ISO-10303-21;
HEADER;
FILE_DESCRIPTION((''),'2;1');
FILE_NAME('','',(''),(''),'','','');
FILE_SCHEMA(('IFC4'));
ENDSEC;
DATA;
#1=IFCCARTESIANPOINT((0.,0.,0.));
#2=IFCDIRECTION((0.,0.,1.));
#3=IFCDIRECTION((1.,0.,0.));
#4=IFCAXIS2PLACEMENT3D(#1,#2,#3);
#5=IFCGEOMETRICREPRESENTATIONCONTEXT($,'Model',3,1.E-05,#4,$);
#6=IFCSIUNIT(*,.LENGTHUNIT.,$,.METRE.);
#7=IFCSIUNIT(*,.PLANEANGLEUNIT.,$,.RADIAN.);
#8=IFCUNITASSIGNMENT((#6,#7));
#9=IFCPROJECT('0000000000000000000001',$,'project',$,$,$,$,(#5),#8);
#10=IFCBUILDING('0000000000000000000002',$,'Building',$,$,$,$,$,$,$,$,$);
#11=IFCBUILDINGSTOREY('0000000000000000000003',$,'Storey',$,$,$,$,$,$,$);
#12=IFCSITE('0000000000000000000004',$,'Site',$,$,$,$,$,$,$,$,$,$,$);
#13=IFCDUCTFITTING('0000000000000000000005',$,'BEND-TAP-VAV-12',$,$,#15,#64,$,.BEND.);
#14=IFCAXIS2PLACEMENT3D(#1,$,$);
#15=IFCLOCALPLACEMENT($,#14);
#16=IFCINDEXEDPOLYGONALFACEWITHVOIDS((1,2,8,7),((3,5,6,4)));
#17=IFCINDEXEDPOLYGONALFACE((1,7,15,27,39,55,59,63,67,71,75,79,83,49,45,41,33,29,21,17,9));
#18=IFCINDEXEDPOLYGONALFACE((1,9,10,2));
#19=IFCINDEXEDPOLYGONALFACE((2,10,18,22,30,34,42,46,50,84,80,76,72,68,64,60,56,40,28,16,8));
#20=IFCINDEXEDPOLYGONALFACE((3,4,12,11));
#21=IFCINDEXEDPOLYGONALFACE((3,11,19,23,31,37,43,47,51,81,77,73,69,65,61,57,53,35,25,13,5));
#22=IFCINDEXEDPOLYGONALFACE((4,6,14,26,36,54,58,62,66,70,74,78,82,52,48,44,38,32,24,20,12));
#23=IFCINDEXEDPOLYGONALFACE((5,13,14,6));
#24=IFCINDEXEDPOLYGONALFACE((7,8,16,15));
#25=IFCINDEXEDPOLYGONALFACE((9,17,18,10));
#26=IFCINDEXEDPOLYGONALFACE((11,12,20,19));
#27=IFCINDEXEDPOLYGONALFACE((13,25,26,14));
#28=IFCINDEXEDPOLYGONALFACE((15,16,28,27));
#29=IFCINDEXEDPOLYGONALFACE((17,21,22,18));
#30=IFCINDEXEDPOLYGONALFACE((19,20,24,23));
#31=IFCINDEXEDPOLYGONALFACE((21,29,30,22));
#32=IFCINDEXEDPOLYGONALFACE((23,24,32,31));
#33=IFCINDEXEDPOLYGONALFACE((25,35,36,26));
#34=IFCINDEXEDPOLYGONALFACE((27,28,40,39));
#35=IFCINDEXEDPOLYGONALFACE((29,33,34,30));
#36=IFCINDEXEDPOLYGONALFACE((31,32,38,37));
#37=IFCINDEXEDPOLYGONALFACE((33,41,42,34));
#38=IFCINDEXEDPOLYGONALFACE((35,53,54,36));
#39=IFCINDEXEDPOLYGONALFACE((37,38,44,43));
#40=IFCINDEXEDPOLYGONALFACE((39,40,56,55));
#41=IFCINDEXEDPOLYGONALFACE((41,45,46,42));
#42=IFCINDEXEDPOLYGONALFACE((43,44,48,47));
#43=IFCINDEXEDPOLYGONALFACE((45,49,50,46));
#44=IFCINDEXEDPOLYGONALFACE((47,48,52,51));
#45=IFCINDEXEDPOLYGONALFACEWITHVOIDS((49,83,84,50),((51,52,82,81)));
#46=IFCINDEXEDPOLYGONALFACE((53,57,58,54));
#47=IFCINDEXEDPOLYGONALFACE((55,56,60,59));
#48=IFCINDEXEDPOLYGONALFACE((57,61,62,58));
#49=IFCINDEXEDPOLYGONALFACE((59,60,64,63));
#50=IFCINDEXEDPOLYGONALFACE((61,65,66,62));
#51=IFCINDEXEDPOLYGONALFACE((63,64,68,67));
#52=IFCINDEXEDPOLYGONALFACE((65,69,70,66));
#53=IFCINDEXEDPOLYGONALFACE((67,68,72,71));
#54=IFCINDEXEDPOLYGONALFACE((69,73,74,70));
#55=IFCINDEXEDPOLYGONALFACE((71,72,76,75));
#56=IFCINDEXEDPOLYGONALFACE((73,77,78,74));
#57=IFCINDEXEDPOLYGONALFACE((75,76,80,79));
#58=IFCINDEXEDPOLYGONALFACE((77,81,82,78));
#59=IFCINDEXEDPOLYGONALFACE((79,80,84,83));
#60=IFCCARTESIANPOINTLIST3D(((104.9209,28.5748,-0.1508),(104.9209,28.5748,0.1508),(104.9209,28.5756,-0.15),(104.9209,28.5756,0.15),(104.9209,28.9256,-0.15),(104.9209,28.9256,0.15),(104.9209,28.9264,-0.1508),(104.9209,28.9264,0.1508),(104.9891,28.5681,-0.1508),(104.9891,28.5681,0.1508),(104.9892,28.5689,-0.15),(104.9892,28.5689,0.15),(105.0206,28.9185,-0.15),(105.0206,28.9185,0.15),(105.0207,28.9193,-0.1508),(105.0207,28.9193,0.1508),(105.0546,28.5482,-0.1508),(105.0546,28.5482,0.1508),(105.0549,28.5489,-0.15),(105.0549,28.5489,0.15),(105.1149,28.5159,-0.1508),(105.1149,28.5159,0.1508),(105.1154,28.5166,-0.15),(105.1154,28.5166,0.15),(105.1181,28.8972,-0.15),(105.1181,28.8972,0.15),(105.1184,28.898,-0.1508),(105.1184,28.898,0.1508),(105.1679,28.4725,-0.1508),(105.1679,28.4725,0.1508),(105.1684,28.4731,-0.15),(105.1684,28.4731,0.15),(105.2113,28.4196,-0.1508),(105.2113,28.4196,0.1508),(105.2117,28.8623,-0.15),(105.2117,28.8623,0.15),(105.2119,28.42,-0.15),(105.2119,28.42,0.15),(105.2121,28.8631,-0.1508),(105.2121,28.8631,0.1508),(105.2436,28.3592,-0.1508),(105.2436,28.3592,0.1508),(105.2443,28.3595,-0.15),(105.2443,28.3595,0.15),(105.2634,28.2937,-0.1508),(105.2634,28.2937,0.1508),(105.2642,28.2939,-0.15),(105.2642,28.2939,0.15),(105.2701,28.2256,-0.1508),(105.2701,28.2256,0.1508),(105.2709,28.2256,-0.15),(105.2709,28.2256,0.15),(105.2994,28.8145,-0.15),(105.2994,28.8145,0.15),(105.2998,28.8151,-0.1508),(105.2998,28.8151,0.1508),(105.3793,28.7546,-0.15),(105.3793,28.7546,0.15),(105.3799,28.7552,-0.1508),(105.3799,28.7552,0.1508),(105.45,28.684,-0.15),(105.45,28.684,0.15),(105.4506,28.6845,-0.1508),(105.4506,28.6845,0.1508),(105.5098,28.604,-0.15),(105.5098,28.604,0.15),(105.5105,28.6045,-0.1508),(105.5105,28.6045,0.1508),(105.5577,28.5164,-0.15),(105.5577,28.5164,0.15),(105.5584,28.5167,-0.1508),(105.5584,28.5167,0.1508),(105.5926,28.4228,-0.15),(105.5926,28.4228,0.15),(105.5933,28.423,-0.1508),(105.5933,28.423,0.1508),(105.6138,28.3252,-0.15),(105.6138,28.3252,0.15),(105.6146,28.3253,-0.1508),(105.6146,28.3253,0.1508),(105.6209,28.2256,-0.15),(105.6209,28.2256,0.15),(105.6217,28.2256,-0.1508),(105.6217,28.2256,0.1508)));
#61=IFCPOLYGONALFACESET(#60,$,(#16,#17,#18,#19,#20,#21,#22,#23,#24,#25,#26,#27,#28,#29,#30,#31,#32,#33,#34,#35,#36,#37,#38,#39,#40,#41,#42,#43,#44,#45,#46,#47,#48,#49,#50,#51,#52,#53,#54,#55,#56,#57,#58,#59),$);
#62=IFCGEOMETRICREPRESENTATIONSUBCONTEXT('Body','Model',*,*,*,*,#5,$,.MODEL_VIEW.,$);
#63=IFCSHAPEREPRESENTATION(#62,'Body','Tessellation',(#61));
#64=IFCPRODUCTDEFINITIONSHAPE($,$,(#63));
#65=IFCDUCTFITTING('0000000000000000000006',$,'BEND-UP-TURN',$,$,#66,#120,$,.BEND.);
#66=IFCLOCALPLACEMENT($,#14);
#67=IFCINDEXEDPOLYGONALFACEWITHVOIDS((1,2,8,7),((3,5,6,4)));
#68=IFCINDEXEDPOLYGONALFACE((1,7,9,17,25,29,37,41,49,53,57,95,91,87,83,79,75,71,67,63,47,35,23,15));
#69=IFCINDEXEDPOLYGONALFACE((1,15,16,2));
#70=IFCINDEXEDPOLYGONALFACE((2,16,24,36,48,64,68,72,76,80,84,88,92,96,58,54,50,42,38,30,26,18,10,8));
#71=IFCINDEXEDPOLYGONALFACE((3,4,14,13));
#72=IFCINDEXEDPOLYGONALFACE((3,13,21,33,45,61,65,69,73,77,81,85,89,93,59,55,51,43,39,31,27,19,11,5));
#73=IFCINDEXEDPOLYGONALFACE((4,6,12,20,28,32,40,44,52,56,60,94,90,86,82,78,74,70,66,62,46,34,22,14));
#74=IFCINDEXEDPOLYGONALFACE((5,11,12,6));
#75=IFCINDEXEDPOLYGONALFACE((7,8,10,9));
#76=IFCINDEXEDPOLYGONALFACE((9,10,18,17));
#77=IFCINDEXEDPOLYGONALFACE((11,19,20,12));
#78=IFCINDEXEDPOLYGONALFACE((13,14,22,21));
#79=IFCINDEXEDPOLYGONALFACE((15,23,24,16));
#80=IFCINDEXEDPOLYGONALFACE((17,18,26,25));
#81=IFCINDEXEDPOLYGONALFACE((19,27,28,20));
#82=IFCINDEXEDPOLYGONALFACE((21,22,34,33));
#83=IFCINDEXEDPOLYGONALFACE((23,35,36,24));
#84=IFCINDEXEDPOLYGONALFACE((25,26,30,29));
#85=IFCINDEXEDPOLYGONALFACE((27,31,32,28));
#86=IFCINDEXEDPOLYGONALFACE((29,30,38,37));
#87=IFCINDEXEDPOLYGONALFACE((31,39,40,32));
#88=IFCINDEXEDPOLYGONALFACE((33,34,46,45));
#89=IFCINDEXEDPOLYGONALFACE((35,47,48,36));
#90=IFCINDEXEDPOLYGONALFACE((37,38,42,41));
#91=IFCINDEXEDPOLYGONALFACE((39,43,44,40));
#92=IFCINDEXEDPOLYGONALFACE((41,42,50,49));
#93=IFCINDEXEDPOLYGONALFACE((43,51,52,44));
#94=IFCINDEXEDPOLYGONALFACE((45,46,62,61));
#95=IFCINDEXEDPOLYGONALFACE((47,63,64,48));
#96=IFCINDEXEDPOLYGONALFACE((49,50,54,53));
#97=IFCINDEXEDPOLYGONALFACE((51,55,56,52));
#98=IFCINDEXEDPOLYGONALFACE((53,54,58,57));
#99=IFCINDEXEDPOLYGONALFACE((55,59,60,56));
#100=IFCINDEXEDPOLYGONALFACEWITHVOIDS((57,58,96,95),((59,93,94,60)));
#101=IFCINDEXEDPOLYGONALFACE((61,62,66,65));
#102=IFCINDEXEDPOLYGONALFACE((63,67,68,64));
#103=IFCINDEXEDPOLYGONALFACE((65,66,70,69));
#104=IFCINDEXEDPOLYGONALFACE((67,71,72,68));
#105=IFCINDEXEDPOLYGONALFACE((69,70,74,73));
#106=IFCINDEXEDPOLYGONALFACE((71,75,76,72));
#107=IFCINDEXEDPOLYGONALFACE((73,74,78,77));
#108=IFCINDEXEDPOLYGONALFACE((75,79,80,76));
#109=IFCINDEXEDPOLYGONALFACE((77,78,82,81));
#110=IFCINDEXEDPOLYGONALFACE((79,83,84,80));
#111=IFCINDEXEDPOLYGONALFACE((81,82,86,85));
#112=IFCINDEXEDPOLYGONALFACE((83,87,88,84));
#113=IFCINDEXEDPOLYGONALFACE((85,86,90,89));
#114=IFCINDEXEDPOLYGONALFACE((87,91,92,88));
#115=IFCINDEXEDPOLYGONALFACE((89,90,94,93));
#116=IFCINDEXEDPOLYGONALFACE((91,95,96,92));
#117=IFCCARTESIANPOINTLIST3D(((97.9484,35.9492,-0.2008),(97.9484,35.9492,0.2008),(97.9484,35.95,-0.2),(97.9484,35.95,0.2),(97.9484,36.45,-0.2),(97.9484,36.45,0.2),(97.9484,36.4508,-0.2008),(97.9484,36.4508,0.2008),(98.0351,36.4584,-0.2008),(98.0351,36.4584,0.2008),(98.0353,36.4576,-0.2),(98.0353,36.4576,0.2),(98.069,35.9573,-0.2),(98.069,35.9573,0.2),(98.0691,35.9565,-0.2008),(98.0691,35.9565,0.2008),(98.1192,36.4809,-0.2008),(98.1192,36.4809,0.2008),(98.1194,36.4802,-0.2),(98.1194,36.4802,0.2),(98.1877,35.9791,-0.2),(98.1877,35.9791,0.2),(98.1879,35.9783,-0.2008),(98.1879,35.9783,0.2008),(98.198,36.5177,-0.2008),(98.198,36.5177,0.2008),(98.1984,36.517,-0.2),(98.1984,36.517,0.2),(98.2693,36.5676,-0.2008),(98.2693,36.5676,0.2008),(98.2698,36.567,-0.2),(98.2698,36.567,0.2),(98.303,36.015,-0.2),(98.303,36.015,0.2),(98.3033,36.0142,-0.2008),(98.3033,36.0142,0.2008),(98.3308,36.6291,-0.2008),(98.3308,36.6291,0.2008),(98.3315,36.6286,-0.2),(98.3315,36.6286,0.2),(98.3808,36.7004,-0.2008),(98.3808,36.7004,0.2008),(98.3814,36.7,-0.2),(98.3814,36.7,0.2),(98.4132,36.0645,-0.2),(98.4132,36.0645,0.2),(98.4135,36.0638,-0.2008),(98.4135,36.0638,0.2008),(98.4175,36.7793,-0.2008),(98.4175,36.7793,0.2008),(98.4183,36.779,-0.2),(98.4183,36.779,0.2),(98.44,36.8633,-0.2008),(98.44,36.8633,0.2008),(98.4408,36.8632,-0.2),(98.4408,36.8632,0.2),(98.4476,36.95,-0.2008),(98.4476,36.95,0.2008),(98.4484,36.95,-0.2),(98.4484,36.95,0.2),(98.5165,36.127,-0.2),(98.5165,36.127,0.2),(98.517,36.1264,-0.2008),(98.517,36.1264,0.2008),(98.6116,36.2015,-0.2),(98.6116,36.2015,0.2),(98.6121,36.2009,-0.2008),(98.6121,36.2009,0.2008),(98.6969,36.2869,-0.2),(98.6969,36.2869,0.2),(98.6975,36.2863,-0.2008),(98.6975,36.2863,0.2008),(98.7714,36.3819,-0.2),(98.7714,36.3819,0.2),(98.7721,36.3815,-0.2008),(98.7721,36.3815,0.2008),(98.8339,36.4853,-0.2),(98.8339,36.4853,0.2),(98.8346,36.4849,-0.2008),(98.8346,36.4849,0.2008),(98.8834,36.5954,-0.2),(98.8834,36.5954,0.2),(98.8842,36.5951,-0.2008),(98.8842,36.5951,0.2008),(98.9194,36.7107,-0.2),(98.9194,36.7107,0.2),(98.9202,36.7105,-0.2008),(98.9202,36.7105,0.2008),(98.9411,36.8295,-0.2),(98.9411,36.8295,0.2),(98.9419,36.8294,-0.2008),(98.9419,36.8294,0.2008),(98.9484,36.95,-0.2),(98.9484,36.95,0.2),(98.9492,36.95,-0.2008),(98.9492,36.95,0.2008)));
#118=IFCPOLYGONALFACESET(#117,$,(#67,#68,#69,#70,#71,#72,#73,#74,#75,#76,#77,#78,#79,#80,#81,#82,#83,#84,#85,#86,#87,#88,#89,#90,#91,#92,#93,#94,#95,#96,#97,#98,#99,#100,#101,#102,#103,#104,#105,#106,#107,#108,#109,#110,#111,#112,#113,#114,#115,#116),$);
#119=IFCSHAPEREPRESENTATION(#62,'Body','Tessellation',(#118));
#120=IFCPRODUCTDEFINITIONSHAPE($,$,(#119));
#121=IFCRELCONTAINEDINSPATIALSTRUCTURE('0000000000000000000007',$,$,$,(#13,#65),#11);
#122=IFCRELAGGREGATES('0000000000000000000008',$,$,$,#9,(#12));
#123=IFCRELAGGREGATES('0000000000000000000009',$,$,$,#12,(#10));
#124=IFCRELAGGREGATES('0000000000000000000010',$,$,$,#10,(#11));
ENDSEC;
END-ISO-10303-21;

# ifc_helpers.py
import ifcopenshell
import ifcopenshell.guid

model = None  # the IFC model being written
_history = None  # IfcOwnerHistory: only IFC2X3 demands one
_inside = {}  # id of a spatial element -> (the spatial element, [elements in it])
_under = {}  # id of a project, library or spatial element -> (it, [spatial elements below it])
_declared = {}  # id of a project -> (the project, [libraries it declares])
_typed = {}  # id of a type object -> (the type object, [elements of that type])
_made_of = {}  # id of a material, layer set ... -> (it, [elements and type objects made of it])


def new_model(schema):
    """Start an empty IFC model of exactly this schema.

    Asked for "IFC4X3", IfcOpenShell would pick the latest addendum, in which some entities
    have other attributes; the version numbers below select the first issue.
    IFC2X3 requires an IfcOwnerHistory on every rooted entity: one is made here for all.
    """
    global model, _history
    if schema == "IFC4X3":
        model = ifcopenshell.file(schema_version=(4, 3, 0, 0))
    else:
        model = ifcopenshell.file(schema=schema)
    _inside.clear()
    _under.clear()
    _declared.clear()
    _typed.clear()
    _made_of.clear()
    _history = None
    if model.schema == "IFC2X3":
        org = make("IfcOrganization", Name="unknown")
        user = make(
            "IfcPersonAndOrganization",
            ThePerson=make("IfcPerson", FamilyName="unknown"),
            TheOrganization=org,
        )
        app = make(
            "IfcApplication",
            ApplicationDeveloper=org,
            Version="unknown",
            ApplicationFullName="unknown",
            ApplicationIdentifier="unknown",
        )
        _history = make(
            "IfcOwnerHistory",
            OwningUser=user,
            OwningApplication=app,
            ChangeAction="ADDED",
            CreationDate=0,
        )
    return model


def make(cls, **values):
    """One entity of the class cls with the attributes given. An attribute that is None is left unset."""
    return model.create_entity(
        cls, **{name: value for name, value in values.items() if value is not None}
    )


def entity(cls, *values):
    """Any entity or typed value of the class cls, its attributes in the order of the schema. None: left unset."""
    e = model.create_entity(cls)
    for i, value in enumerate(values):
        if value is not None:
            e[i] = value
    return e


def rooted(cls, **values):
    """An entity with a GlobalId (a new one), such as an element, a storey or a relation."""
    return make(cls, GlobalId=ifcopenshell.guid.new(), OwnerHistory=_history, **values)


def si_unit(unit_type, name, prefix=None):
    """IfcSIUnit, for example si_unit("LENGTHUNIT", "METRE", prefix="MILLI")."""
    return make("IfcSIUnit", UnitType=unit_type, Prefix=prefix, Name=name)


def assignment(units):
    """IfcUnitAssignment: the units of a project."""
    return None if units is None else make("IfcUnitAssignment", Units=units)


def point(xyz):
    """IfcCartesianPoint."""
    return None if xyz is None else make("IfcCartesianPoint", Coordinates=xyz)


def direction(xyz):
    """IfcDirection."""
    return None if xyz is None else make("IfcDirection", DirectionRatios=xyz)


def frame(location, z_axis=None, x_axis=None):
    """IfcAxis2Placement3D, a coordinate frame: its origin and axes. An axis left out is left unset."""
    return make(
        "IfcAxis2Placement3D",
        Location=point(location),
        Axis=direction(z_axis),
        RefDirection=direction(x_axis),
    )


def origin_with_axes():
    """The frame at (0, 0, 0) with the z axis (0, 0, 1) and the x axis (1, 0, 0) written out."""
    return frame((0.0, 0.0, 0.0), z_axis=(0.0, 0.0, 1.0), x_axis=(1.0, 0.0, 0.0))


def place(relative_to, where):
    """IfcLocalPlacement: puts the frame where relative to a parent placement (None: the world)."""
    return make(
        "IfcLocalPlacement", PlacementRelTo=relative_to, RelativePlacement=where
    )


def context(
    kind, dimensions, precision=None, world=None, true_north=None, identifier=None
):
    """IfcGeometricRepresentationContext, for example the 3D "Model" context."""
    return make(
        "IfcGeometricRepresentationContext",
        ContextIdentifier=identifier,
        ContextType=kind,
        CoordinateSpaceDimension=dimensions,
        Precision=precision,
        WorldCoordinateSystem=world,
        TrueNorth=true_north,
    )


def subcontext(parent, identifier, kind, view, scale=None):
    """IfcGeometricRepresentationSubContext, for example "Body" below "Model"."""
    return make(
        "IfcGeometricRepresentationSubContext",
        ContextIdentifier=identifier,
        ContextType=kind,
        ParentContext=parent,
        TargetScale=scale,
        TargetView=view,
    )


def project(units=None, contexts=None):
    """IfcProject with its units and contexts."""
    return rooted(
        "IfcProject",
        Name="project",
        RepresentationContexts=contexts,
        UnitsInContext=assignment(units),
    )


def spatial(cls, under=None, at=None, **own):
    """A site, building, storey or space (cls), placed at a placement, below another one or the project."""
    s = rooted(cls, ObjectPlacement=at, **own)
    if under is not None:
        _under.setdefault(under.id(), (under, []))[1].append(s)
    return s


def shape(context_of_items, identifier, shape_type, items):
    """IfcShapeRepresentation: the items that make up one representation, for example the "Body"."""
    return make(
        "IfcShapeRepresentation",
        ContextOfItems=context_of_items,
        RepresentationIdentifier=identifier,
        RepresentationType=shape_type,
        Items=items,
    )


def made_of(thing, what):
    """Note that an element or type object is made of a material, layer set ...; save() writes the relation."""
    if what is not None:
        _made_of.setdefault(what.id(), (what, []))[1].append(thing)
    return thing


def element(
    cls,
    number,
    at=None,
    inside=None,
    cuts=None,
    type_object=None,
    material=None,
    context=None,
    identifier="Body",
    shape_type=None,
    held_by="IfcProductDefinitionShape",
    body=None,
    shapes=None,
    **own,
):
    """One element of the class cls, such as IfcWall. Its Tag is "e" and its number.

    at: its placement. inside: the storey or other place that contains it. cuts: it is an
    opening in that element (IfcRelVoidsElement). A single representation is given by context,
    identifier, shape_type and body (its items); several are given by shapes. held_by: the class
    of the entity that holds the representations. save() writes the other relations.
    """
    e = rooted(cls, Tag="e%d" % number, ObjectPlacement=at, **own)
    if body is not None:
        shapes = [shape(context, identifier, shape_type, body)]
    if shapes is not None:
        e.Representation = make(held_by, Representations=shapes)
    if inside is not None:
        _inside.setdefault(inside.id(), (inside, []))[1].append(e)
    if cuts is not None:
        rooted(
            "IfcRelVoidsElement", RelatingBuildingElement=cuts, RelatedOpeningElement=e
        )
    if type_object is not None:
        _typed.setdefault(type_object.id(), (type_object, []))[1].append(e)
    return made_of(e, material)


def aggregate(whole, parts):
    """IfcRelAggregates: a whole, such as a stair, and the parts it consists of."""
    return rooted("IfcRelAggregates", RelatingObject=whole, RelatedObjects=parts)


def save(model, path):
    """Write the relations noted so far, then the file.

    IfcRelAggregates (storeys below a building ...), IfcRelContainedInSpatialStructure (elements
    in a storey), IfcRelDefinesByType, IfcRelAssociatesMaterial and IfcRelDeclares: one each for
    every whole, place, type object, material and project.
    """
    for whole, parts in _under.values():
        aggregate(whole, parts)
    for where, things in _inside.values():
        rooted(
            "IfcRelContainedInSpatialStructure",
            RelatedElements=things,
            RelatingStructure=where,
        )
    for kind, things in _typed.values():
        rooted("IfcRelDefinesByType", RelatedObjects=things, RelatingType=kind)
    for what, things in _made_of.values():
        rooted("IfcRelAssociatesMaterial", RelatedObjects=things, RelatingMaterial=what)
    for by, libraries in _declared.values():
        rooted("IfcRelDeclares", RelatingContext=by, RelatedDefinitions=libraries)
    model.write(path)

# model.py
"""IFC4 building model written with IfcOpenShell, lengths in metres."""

from ifc_helpers import new_model, entity, si_unit, frame, origin_with_axes, place, context, subcontext, project, spatial, element, save


model = new_model("IFC4")

# Units and contexts
model_context = context("Model", 3, precision=1e-05, world=origin_with_axes())
body_context = subcontext(model_context, "Body", "Model", "MODEL_VIEW")
ifc_project = project(units=[si_unit("LENGTHUNIT", "METRE"), si_unit("PLANEANGLEUNIT", "RADIAN")], contexts=[model_context])

# Site, building, storey
site = spatial("IfcSite", under=ifc_project, Name="Site")
building = spatial("IfcBuilding", under=site, Name="Building")
storey = spatial("IfcBuildingStorey", under=building, Name="Storey")

# Duct fittings
duct_fitting_1_placement = place(None, frame((104.9209, 28.2256, 0.0), z_axis=(0.0, 0.0, -1.0), x_axis=(0.0, 1.0, 0.0)))
cartesian_point_1 = entity("IfcCartesianPoint", [0.0, 0.0, 0.0])
element("IfcDuctFitting", 1, at=duct_fitting_1_placement, inside=storey, Name="BEND-TAP-VAV-12", PredefinedType="BEND", context=body_context, shape_type="SweptSolid", body=[
    entity("IfcRevolvedAreaSolid", entity("IfcRectangleHollowProfileDef", "AREA", None, entity("IfcAxis2Placement2D", entity("IfcCartesianPoint", [0.525, 0.0])), 0.3516, 0.3016, 0.0008), entity("IfcAxis2Placement3D", cartesian_point_1, entity("IfcDirection", [0.0, -1.0, 0.0]), entity("IfcDirection", [1.0, 0.0, 0.0])), entity("IfcAxis1Placement", cartesian_point_1, entity("IfcDirection", [0.0, 1.0, 0.0])), 1.570796),
])
duct_fitting_2_placement = place(None, frame((97.9484, 36.95, 0.0), z_axis=(0.0, 0.0, 1.0), x_axis=(0.0, -1.0, 0.0)))
cartesian_point_2 = entity("IfcCartesianPoint", [0.0, 0.0, 0.0])
element("IfcDuctFitting", 2, at=duct_fitting_2_placement, inside=storey, Name="BEND-UP-TURN", PredefinedType="BEND", context=body_context, shape_type="SweptSolid", body=[
    entity("IfcRevolvedAreaSolid", entity("IfcRectangleHollowProfileDef", "AREA", None, entity("IfcAxis2Placement2D", entity("IfcCartesianPoint", [0.75, 0.0])), 0.5016, 0.4016, 0.0008), entity("IfcAxis2Placement3D", cartesian_point_2, entity("IfcDirection", [0.0, -1.0, 0.0]), entity("IfcDirection", [1.0, 0.0, 0.0])), entity("IfcAxis1Placement", cartesian_point_2, entity("IfcDirection", [0.0, 1.0, 0.0])), 1.570796),
])

save(model, "model.ifc")
